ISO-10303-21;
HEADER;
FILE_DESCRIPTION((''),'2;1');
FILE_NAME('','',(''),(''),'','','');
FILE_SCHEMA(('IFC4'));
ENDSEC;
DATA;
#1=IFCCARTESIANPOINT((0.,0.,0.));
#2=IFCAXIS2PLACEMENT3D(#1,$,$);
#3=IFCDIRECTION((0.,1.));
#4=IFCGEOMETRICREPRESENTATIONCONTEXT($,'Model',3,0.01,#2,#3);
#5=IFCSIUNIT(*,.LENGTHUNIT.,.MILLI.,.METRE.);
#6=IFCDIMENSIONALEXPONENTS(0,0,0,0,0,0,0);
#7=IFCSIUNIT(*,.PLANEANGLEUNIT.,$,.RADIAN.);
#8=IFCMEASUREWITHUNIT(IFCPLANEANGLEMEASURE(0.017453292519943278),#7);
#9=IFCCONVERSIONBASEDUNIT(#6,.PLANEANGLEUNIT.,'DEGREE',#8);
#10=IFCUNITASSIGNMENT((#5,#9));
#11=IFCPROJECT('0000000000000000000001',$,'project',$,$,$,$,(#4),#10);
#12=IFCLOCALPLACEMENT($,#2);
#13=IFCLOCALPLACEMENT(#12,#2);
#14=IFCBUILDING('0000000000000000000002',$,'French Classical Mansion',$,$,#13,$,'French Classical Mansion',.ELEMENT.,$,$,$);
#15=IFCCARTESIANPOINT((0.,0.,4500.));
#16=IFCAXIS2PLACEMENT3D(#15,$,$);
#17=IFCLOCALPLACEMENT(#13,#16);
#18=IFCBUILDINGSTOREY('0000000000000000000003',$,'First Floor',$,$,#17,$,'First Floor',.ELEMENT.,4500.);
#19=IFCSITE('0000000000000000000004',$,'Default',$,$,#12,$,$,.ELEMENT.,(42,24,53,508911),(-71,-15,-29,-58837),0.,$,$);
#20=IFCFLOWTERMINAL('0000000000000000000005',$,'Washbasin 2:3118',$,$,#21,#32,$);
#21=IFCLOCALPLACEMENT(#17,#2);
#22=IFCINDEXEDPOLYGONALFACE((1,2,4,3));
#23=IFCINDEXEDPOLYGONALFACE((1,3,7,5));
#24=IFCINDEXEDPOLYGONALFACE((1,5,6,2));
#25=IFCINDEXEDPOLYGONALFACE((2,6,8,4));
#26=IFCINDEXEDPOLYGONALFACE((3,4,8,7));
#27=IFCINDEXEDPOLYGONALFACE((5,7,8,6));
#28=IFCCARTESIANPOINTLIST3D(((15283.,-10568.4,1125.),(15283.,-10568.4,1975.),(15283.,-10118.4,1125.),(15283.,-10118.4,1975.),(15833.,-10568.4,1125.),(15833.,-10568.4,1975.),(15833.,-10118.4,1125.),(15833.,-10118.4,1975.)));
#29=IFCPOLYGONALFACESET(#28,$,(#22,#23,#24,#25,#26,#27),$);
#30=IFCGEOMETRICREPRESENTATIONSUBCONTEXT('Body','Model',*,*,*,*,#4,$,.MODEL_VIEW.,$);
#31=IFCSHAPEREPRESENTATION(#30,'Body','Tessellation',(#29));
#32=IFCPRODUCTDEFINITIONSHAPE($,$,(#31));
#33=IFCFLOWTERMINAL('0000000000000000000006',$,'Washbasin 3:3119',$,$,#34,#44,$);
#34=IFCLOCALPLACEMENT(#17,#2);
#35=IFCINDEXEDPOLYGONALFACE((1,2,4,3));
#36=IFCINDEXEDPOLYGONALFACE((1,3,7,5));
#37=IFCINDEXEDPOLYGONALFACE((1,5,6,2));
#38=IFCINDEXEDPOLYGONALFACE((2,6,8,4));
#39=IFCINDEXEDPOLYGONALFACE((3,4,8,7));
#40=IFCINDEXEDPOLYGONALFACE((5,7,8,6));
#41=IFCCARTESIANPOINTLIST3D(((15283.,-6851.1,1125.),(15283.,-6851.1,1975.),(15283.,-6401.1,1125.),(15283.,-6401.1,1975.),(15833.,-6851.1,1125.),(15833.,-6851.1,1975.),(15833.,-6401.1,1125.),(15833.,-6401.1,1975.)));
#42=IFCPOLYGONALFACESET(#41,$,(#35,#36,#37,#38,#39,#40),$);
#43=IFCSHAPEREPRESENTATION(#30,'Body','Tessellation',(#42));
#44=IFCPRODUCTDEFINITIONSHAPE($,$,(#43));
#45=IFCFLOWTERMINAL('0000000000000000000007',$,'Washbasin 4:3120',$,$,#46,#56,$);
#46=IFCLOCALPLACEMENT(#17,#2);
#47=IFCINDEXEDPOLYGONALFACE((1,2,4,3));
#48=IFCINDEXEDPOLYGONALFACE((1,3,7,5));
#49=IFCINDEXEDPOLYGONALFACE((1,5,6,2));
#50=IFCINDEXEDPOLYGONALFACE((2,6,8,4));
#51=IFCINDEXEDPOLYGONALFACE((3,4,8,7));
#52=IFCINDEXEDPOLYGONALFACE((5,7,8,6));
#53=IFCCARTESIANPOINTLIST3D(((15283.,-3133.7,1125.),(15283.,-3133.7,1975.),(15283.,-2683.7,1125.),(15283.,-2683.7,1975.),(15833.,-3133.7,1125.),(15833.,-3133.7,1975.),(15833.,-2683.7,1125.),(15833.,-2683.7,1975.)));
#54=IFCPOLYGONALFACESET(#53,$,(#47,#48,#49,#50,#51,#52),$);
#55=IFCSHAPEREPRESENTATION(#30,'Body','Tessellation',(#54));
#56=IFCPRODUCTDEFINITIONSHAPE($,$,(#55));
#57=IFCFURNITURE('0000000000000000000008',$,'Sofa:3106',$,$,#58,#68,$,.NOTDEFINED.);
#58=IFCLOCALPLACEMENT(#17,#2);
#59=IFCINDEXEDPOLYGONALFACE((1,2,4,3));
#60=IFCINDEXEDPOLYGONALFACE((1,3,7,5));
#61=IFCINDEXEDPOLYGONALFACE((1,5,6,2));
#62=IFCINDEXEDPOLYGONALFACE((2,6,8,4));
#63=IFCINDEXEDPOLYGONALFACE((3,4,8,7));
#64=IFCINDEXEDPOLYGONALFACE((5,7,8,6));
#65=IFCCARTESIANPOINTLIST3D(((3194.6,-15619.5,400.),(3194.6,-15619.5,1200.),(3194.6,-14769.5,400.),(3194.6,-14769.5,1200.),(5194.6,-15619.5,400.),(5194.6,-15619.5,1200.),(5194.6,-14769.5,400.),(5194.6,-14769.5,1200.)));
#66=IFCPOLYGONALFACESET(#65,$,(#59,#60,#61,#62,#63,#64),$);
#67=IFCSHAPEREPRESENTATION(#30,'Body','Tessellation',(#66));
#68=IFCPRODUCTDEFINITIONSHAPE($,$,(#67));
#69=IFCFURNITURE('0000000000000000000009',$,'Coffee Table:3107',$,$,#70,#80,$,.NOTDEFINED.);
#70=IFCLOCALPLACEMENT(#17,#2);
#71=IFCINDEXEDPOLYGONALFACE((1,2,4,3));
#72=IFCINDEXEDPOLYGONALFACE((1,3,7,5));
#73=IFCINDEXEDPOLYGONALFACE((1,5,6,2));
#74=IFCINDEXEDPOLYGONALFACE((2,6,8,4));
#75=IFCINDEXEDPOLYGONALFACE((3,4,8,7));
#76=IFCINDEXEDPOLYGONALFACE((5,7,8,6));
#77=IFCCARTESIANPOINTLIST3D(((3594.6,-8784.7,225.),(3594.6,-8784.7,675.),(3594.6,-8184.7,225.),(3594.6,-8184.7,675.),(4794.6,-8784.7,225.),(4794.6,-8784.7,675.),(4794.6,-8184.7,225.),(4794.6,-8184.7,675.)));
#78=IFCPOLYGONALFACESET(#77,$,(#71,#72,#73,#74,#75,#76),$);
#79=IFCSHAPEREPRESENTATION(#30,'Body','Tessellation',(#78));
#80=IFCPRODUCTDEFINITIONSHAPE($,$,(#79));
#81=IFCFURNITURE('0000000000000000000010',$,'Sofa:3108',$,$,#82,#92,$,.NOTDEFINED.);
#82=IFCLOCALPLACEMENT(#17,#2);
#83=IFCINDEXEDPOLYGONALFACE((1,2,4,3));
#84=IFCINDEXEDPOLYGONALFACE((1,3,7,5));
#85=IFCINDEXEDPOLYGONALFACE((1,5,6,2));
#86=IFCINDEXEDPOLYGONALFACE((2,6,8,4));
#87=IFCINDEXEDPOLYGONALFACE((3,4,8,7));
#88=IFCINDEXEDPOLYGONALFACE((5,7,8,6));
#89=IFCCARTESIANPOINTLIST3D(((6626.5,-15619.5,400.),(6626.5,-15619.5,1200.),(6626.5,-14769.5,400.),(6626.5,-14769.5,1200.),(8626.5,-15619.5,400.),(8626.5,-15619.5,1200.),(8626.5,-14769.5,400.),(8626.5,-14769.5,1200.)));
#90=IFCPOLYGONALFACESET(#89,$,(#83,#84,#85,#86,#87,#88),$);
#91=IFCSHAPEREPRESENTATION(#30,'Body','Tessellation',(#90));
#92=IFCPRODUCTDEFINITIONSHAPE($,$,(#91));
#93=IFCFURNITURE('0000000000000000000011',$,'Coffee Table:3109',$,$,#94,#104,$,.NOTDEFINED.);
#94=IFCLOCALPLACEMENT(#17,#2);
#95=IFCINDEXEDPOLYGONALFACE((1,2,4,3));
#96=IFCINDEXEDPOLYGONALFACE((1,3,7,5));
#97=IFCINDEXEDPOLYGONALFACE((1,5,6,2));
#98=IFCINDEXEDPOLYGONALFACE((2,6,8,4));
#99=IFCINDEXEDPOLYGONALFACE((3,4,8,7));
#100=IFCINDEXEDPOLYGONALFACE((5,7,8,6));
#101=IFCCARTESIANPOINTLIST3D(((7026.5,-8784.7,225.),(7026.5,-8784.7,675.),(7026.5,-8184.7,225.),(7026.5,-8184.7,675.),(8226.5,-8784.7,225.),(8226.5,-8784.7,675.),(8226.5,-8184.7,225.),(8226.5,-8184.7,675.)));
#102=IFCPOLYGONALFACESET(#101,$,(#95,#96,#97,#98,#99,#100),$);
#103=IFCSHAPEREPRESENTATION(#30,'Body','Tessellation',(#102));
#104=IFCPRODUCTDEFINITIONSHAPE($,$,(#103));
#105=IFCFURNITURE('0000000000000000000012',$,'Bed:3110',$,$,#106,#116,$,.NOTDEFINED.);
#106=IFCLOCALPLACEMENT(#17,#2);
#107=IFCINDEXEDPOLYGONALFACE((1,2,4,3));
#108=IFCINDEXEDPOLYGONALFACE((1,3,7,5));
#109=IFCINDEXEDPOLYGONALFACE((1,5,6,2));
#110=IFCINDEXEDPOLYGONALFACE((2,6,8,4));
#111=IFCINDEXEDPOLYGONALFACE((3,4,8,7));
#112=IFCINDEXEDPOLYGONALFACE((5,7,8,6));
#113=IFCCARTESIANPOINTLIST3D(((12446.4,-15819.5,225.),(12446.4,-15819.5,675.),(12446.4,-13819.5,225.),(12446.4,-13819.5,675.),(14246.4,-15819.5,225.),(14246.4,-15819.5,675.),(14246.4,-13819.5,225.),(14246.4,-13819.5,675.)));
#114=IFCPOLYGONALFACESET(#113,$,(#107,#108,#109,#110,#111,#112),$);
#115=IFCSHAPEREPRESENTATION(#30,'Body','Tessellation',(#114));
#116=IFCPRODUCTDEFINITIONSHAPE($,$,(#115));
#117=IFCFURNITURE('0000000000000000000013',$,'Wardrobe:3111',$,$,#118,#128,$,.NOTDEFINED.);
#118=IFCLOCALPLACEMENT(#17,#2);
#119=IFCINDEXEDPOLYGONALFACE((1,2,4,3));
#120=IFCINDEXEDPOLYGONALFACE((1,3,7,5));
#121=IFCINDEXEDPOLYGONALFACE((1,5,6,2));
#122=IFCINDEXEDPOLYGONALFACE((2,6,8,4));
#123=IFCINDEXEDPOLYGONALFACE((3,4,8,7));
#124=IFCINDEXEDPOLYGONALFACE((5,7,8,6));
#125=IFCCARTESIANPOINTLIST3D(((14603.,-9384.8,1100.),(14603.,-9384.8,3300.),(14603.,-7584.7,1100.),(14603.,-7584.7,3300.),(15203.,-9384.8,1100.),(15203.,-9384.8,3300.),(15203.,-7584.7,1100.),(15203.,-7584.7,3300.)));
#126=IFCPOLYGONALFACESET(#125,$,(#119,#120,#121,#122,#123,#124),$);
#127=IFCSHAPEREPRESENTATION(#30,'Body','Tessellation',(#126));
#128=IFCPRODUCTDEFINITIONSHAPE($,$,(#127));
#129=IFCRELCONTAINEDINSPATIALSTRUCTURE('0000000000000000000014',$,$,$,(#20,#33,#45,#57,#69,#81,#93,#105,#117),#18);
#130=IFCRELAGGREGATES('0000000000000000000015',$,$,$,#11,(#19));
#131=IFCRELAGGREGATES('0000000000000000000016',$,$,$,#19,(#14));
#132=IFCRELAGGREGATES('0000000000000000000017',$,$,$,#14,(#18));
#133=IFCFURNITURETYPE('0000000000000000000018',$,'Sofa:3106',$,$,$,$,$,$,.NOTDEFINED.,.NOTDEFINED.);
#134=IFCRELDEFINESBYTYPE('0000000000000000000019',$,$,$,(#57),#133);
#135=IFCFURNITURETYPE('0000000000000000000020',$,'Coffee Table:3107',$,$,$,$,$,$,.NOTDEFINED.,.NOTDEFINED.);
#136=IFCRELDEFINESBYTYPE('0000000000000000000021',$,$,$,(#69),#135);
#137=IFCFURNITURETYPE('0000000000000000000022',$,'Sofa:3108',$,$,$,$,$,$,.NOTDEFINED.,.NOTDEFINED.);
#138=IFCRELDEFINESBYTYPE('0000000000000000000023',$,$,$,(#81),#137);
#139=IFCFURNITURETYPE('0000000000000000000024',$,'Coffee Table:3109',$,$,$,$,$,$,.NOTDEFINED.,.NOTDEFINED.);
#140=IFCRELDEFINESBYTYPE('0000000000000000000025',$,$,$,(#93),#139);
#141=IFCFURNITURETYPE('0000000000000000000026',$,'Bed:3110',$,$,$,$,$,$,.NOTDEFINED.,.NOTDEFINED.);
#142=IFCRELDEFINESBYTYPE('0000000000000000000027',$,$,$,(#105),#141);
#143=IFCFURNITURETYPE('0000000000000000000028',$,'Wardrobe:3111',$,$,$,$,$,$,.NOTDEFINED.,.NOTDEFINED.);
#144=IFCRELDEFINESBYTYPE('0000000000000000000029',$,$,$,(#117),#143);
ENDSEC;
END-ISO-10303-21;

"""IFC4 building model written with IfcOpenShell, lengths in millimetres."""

from ifc_helpers import new_model, entity, si_unit, converted_unit, direction, frame, frame_2d, origin, origin_2d_with_axis, place, context, subcontext, project, spatial, rectangle, extrude, type_object, element, save


model = new_model("IFC4")

# Units and contexts
model_context = context("Model", 3, precision=0.01, world=origin(), true_north=direction((0.0, 1.0)))
body_context = subcontext(model_context, "Body", "Model", "MODEL_VIEW")
ifc_project = project(units=[si_unit("LENGTHUNIT", "METRE", prefix="MILLI"), converted_unit("PLANEANGLEUNIT", "DEGREE", entity("IfcPlaneAngleMeasure", 0.017453292519943278), si_unit("PLANEANGLEUNIT", "RADIAN"), dimensions=[0, 0, 0, 0, 0, 0, 0])], contexts=[model_context])

# Site, building, storey
site_placement = place(None, origin())
site = spatial("IfcSite", under=ifc_project, at=site_placement, Name="Default", CompositionType="ELEMENT", RefLatitude=(42, 24, 53, 508911), RefLongitude=(-71, -15, -29, -58837), RefElevation=0.0)
building_placement = place(site_placement, origin())
building = spatial("IfcBuilding", under=site, at=building_placement, Name="French Classical Mansion", LongName="French Classical Mansion", CompositionType="ELEMENT")
storey_placement = place(building_placement, frame((0.0, 0.0, 4500.0)))
storey = spatial("IfcBuildingStorey", under=building, at=storey_placement, Name="First Floor", LongName="First Floor", CompositionType="ELEMENT", Elevation=4500.0)

# Flow terminals
flow_terminal_1_placement = place(storey_placement, origin())
element("IfcFlowTerminal", 1, at=flow_terminal_1_placement, inside=storey, Name="Washbasin 2:3118", context=body_context, shape_type="SweptSolid", body=[
    extrude(rectangle(XDim=450.0, YDim=550.0, at=origin_2d_with_axis()), frame((15558.0, -10343.4, 1125.0), z_axis=(0.0, 0.0, 1.0), x_axis=(0.0, 1.0, 0.0)), (0.0, 0.0, 1.0), 850.0),
])
flow_terminal_2_placement = place(storey_placement, origin())
element("IfcFlowTerminal", 2, at=flow_terminal_2_placement, inside=storey, Name="Washbasin 3:3119", context=body_context, shape_type="SweptSolid", body=[
    extrude(rectangle(XDim=450.0, YDim=550.0, at=origin_2d_with_axis()), frame((15558.0, -6626.1, 1125.0), z_axis=(0.0, 0.0, 1.0), x_axis=(0.0, 1.0, 0.0)), (0.0, 0.0, 1.0), 850.0),
])
flow_terminal_3_placement = place(storey_placement, origin())
element("IfcFlowTerminal", 3, at=flow_terminal_3_placement, inside=storey, Name="Washbasin 4:3120", context=body_context, shape_type="SweptSolid", body=[
    extrude(rectangle(XDim=450.0, YDim=550.0, at=origin_2d_with_axis()), frame((15558.0, -2908.7, 1125.0), z_axis=(0.0, 0.0, 1.0), x_axis=(0.0, 1.0, 0.0)), (0.0, 0.0, 1.0), 850.0),
])

# Furniture
furniture_type_1 = type_object("IfcFurnitureType", Name="Sofa:3106", PredefinedType="NOTDEFINED")
furniture_1_placement = place(storey_placement, origin())
element("IfcFurniture", 4, at=furniture_1_placement, inside=storey, type_object=furniture_type_1, Name="Sofa:3106", PredefinedType="NOTDEFINED", context=body_context, shape_type="SweptSolid", body=[
    extrude(rectangle(XDim=2000.0, YDim=850.0, at=frame_2d((0.0, 0.0), x_axis=(1.0, 0.0))), frame((4194.6, -15194.5, 400.0)), (0.0, 0.0, 1.0), 800.0),
])
furniture_type_2 = type_object("IfcFurnitureType", Name="Coffee Table:3107", PredefinedType="NOTDEFINED")
furniture_2_placement = place(storey_placement, origin())
element("IfcFurniture", 5, at=furniture_2_placement, inside=storey, type_object=furniture_type_2, Name="Coffee Table:3107", PredefinedType="NOTDEFINED", context=body_context, shape_type="SweptSolid", body=[
    extrude(rectangle(XDim=1200.0, YDim=600.0, at=frame_2d((0.0, 0.0), x_axis=(1.0, 0.0))), frame((4194.6, -8484.7, 225.0)), (0.0, 0.0, 1.0), 450.0),
])
furniture_type_3 = type_object("IfcFurnitureType", Name="Sofa:3108", PredefinedType="NOTDEFINED")
furniture_3_placement = place(storey_placement, origin())
element("IfcFurniture", 6, at=furniture_3_placement, inside=storey, type_object=furniture_type_3, Name="Sofa:3108", PredefinedType="NOTDEFINED", context=body_context, shape_type="SweptSolid", body=[
    extrude(rectangle(XDim=2000.0, YDim=850.0, at=frame_2d((0.0, 0.0), x_axis=(1.0, 0.0))), frame((7626.5, -15194.5, 400.0)), (0.0, 0.0, 1.0), 800.0),
])
furniture_type_4 = type_object("IfcFurnitureType", Name="Coffee Table:3109", PredefinedType="NOTDEFINED")
furniture_4_placement = place(storey_placement, origin())
element("IfcFurniture", 7, at=furniture_4_placement, inside=storey, type_object=furniture_type_4, Name="Coffee Table:3109", PredefinedType="NOTDEFINED", context=body_context, shape_type="SweptSolid", body=[
    extrude(rectangle(XDim=1200.0, YDim=600.0, at=frame_2d((0.0, 0.0), x_axis=(1.0, 0.0))), frame((7626.5, -8484.7, 225.0)), (0.0, 0.0, 1.0), 450.0),
])
furniture_type_5 = type_object("IfcFurnitureType", Name="Bed:3110", PredefinedType="NOTDEFINED")
furniture_5_placement = place(storey_placement, origin())
element("IfcFurniture", 8, at=furniture_5_placement, inside=storey, type_object=furniture_type_5, Name="Bed:3110", PredefinedType="NOTDEFINED", context=body_context, shape_type="SweptSolid", body=[
    extrude(rectangle(XDim=1800.0, YDim=2000.0, at=origin_2d_with_axis()), frame((13346.4, -14819.5, 225.0)), (0.0, 0.0, 1.0), 450.0),
])
furniture_type_6 = type_object("IfcFurnitureType", Name="Wardrobe:3111", PredefinedType="NOTDEFINED")
furniture_6_placement = place(storey_placement, origin())
element("IfcFurniture", 9, at=furniture_6_placement, inside=storey, type_object=furniture_type_6, Name="Wardrobe:3111", PredefinedType="NOTDEFINED", context=body_context, shape_type="SweptSolid", body=[
    extrude(rectangle(XDim=600.0, YDim=1800.0, at=origin_2d_with_axis()), frame((14903.0, -8484.8, 1100.0)), (0.0, 0.0, 1.0), 2200.0),
])

save(model, "model.ifc")
